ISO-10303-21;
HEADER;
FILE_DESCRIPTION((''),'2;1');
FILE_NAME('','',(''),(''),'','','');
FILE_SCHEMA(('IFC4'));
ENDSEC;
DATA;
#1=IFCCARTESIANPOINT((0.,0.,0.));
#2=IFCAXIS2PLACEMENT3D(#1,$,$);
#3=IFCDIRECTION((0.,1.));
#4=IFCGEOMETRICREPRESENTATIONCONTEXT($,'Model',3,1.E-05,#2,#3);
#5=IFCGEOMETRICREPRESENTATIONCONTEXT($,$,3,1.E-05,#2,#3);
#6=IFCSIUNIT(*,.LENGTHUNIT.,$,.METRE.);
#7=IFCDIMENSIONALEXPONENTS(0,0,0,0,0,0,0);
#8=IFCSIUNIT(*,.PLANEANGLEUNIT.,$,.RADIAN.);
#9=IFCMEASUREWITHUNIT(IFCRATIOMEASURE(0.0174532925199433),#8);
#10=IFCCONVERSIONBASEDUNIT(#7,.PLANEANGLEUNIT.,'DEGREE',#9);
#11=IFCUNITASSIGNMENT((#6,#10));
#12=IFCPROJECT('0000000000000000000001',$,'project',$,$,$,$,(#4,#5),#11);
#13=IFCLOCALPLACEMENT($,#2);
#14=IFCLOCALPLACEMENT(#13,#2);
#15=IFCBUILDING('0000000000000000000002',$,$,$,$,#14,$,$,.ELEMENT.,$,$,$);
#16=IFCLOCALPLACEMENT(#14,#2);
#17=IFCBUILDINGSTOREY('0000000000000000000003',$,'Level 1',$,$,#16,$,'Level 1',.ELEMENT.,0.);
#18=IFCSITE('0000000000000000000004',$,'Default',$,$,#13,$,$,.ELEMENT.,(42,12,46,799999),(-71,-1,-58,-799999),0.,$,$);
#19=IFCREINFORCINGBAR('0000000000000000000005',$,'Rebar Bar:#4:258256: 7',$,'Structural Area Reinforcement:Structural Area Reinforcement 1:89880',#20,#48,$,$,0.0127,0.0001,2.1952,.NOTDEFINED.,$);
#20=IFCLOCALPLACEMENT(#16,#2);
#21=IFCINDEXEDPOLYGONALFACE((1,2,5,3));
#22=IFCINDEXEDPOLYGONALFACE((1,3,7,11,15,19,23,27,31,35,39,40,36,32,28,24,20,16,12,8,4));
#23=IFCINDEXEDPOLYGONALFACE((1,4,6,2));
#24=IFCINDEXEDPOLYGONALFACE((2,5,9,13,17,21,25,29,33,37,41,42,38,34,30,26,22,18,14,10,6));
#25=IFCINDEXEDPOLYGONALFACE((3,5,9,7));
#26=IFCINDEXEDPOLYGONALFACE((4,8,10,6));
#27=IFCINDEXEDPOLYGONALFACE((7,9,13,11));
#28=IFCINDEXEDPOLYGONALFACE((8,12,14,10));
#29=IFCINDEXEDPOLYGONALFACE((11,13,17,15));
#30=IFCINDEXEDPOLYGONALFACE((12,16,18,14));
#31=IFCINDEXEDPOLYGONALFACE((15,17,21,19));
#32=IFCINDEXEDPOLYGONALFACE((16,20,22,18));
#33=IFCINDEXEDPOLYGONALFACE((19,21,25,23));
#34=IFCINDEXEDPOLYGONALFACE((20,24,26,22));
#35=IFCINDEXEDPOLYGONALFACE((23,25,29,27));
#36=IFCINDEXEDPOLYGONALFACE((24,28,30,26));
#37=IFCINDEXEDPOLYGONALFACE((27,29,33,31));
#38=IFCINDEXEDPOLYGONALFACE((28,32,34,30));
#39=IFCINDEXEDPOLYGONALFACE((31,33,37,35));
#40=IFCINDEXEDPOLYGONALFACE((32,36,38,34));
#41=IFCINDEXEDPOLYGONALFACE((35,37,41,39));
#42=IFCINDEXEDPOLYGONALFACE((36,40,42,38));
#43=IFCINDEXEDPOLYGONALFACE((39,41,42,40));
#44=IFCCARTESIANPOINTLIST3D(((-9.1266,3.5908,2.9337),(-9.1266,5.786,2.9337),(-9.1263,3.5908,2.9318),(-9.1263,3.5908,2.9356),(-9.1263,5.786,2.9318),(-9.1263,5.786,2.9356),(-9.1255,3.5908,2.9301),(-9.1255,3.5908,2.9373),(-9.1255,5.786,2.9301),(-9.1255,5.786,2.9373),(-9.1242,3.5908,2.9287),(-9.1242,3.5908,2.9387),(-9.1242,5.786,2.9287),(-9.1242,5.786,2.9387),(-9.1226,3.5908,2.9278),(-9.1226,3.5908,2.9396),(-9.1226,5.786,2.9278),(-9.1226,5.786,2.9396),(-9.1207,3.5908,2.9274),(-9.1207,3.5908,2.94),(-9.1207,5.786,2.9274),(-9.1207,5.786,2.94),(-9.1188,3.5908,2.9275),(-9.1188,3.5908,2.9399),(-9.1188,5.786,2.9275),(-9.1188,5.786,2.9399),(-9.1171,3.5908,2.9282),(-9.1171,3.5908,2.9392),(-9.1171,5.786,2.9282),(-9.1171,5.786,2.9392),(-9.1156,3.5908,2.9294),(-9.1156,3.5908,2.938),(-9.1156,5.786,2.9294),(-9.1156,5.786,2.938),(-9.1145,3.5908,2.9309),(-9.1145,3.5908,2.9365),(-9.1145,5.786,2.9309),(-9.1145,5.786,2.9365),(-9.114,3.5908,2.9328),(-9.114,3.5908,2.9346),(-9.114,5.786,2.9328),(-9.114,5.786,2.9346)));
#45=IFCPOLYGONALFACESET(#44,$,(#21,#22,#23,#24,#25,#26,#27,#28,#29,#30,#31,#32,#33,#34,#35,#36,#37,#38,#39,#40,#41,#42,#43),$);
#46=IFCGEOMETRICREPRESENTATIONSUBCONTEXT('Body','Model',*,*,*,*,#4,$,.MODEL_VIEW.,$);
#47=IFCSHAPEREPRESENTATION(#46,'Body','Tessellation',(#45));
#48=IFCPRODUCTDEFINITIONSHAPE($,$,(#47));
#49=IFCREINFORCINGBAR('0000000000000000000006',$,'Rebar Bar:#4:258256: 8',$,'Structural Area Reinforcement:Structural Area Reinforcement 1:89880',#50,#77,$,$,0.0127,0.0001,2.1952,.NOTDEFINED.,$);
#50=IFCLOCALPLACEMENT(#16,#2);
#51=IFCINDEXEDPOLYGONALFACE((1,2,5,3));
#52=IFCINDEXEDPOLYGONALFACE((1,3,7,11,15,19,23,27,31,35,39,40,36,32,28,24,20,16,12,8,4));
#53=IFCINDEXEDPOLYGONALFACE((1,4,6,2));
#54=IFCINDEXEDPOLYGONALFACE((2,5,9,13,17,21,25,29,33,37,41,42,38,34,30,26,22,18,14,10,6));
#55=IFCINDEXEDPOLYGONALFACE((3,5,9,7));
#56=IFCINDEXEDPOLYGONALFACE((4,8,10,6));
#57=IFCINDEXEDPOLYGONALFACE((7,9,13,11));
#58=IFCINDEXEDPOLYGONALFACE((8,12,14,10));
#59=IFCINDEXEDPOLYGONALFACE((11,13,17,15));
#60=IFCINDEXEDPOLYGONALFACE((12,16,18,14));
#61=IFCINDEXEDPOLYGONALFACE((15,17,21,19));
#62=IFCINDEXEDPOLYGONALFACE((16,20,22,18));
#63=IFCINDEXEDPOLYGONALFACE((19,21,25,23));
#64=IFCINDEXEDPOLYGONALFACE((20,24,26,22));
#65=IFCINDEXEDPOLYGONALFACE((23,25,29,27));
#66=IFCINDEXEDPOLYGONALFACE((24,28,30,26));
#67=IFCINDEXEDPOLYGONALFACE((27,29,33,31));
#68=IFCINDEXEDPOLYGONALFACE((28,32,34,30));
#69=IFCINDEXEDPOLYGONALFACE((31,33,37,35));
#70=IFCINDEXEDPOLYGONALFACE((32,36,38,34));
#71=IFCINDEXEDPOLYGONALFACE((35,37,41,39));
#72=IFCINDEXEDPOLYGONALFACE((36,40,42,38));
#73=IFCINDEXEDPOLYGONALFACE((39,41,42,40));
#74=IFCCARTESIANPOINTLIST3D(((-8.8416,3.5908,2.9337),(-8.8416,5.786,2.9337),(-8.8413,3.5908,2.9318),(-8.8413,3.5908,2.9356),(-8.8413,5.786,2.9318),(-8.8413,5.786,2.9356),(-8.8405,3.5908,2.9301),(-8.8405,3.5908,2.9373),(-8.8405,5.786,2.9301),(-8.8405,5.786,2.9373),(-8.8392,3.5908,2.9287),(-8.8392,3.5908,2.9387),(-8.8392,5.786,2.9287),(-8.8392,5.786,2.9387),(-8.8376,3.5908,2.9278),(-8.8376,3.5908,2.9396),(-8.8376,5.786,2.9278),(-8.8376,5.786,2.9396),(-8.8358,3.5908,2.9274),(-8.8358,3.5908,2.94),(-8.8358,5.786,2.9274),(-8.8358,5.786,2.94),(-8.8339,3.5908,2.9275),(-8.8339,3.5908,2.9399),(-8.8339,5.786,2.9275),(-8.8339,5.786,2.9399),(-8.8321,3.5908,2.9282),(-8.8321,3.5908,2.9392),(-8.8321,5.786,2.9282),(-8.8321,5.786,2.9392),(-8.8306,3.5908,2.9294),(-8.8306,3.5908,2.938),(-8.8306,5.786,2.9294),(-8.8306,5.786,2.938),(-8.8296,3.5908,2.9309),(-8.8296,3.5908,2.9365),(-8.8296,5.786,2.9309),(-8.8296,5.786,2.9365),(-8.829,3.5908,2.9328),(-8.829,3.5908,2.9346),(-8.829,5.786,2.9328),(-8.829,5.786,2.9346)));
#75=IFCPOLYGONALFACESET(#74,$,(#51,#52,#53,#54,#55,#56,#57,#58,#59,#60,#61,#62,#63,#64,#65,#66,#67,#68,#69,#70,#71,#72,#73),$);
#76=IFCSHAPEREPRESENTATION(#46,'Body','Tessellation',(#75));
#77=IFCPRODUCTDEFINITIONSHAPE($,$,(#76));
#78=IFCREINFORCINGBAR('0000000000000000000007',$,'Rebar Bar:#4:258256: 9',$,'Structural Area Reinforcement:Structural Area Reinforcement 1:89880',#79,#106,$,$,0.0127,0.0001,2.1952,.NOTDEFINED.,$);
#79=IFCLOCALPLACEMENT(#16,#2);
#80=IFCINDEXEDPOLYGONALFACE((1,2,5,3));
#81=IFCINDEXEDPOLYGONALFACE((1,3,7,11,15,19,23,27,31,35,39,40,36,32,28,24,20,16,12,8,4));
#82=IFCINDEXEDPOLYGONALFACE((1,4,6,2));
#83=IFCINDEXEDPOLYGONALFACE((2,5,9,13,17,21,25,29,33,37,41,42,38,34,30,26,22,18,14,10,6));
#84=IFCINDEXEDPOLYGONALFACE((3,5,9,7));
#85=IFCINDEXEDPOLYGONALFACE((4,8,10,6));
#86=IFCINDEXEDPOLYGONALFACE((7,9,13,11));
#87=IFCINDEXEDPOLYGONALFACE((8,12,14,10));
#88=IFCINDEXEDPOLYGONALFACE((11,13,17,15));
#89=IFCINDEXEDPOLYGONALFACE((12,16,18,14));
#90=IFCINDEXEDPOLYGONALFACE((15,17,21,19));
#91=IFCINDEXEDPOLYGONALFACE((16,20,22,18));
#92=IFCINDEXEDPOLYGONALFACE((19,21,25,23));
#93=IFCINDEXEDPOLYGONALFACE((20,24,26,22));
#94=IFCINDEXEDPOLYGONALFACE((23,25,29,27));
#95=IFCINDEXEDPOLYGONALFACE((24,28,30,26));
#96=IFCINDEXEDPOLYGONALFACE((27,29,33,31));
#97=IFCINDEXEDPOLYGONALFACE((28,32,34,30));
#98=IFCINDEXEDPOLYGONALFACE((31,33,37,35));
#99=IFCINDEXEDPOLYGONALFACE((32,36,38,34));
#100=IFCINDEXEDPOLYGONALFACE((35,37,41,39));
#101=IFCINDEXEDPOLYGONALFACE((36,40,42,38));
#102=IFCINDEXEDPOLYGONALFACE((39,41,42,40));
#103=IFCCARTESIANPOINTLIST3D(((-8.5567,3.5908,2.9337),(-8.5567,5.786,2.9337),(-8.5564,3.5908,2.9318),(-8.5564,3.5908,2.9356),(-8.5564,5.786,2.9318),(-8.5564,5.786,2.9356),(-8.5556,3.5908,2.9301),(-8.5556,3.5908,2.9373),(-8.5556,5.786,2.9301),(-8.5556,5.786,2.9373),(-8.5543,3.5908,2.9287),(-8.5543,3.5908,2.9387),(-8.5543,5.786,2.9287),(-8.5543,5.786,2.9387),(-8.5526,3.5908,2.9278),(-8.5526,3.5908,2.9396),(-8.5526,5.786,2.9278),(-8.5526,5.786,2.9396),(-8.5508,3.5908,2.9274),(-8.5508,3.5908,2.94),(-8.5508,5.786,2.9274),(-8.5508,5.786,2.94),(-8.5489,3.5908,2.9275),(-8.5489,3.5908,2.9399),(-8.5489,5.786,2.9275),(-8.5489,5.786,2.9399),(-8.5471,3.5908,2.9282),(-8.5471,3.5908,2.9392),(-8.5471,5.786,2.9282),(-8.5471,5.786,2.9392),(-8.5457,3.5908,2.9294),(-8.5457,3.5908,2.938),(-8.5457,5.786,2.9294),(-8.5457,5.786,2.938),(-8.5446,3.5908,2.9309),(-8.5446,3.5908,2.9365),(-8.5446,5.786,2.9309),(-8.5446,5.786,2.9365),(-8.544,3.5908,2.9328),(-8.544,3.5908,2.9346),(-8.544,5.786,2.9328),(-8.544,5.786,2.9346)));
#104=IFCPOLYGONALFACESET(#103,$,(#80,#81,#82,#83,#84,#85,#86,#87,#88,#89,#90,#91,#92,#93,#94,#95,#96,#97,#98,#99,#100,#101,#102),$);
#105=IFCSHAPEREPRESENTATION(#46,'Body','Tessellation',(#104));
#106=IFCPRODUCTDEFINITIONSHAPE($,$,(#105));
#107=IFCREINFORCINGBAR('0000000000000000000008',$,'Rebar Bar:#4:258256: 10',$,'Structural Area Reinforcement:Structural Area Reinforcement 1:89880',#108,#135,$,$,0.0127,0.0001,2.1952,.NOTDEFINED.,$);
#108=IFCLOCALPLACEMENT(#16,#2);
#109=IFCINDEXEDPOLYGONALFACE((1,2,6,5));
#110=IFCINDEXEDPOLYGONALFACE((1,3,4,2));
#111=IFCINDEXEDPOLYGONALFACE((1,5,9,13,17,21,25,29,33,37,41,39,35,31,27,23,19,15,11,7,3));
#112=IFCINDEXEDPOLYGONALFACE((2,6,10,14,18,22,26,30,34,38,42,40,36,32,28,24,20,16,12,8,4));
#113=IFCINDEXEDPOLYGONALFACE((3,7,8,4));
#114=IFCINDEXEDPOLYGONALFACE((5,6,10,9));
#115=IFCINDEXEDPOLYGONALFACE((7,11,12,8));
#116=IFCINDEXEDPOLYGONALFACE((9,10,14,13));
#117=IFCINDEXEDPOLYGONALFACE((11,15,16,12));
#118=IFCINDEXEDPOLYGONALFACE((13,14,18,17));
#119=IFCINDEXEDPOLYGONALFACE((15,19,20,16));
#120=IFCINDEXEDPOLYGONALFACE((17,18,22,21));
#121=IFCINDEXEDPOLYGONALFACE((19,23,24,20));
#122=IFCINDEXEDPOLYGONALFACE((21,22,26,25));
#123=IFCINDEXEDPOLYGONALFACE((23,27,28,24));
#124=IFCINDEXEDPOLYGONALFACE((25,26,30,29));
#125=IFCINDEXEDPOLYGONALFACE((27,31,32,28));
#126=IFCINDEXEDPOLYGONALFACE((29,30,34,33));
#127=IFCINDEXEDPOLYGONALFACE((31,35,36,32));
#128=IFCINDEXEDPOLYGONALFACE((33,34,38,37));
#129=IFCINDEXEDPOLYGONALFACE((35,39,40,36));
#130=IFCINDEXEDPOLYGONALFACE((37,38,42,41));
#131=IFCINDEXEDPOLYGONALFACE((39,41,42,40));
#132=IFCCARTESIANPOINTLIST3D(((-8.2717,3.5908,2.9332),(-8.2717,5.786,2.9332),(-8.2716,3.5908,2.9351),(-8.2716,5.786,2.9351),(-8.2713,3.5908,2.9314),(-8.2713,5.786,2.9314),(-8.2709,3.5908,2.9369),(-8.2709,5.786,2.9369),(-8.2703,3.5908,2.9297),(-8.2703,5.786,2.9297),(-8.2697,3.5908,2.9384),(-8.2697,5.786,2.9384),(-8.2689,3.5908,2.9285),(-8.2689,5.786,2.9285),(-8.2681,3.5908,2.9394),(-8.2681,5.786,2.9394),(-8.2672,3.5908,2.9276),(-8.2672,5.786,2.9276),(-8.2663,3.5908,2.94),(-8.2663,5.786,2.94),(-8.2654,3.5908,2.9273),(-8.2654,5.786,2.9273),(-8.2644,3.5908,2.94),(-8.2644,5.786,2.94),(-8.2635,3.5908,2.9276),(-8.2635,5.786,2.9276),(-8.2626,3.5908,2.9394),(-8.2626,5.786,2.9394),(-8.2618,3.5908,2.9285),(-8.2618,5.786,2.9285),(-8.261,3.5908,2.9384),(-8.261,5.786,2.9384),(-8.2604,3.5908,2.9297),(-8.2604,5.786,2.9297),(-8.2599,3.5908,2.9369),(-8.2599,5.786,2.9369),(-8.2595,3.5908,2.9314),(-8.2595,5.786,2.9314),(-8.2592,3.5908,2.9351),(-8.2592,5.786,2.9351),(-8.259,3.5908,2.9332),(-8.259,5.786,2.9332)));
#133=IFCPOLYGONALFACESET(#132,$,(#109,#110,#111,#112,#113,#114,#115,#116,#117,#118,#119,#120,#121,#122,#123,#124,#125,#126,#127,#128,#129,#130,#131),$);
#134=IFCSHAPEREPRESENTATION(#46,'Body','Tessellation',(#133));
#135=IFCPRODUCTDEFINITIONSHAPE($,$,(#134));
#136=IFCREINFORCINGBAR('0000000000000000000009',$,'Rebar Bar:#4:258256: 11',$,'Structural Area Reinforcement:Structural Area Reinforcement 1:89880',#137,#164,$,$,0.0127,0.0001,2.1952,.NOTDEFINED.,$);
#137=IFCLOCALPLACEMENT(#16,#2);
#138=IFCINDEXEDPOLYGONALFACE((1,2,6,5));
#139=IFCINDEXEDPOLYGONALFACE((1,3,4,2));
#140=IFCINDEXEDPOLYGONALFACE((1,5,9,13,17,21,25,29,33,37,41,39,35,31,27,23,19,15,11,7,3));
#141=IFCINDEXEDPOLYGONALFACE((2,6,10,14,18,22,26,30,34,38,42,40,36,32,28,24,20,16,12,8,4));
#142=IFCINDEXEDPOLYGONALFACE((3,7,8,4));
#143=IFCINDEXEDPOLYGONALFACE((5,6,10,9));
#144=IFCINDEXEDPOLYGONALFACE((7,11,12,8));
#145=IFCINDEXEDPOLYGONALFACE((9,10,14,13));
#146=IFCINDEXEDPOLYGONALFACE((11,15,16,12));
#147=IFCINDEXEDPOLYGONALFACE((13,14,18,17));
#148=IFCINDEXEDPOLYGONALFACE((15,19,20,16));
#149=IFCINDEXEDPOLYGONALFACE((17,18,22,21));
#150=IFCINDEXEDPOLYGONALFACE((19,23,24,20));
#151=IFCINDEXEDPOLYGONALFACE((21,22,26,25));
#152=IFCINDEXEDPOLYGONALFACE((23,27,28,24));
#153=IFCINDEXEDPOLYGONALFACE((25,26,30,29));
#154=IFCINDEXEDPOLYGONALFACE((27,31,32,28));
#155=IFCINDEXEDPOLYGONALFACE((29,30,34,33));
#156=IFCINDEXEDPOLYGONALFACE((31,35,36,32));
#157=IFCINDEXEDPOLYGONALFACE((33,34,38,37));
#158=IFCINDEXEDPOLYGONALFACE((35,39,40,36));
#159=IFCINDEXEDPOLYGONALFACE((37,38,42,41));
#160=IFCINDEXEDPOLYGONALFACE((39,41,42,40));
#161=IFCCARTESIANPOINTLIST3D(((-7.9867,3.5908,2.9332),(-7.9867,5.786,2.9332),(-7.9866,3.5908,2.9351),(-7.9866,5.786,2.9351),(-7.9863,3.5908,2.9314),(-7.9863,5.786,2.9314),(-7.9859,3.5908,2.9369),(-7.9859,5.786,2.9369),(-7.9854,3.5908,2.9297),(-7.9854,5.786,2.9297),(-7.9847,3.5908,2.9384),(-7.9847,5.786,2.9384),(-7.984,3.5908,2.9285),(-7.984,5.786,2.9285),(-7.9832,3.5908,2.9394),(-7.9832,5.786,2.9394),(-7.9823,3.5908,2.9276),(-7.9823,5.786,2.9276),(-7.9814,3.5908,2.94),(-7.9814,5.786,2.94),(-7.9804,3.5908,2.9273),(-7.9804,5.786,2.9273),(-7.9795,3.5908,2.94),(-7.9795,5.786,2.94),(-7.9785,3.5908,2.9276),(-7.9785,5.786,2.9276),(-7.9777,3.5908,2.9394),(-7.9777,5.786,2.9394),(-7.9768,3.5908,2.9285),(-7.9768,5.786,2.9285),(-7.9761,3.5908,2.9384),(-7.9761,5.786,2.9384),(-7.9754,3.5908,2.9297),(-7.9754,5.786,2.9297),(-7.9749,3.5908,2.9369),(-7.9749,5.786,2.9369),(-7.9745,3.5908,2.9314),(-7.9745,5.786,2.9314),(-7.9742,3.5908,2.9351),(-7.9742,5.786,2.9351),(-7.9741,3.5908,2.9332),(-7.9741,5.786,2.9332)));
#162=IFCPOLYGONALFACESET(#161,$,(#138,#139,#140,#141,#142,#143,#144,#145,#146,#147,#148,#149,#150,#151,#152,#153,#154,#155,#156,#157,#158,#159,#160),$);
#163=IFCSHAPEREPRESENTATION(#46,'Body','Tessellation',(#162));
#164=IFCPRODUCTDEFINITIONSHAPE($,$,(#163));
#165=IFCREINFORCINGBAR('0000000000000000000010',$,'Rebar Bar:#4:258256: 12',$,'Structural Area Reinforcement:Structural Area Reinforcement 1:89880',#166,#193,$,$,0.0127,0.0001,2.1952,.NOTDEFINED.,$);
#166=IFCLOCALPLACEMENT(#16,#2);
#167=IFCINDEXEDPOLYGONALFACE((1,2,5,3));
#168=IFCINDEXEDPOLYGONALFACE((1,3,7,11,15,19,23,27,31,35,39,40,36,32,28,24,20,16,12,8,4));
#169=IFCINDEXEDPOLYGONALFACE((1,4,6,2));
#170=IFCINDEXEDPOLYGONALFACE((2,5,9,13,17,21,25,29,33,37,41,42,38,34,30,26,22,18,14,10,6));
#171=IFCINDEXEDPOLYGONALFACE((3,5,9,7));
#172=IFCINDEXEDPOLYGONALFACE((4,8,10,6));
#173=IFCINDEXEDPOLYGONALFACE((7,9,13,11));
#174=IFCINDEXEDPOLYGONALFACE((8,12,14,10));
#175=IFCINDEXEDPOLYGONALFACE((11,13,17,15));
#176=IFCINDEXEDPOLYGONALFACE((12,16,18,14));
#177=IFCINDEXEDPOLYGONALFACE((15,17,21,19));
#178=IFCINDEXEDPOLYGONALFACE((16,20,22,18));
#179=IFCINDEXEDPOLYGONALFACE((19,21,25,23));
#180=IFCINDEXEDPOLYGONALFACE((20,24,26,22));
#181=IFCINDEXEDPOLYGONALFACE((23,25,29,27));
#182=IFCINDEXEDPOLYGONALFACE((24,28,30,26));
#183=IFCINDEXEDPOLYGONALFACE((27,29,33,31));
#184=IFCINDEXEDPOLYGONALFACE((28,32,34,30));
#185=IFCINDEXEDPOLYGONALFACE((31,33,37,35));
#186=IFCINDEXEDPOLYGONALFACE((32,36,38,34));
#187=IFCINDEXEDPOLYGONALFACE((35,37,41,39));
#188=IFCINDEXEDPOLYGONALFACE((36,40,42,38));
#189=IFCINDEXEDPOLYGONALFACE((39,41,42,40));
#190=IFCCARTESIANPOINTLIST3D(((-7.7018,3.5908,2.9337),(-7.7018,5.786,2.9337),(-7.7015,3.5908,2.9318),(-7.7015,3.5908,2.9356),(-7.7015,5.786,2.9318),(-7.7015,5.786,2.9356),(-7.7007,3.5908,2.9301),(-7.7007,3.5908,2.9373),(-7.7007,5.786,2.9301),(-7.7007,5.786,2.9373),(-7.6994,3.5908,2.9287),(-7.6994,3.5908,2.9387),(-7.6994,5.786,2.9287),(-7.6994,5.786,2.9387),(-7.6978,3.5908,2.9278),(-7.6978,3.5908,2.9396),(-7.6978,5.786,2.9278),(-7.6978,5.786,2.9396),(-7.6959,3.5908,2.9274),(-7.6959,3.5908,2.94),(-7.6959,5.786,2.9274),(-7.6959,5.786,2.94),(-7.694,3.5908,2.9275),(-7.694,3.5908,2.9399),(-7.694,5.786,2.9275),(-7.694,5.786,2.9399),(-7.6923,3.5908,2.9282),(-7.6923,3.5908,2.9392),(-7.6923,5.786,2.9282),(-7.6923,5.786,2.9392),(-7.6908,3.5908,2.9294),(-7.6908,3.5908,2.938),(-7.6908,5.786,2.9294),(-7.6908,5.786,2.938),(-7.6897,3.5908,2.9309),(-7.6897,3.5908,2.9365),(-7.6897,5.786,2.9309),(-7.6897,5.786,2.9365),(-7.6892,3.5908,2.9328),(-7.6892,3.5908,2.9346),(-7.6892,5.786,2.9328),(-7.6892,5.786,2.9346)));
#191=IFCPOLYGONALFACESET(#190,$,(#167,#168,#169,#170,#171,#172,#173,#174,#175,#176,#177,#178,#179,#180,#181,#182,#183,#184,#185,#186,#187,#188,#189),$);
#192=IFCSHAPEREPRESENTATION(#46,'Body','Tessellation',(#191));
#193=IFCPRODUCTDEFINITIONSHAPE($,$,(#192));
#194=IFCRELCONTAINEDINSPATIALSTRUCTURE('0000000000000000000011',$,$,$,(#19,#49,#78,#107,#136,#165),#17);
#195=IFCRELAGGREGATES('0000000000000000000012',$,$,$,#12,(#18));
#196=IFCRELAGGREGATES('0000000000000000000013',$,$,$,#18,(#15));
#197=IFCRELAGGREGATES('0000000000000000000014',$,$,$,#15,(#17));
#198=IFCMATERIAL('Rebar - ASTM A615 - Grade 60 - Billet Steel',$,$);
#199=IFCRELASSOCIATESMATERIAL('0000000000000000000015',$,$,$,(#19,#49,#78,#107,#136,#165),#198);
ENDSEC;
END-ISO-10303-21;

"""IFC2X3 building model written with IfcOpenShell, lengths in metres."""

from ifc_helpers import new_model, entity, si_unit, converted_unit, direction, origin, place, context, subcontext, project, spatial, material, element, save


model = new_model("IFC2X3")

# Units and contexts
model_context = context("Model", 3, precision=1e-05, world=origin(), true_north=direction((0.0, 1.0)))
context_of_model = context(None, 3, precision=1e-05, world=origin(), true_north=direction((0.0, 1.0)))
body_context = subcontext(model_context, "Body", "Model", "MODEL_VIEW")
ifc_project = project(units=[si_unit("LENGTHUNIT", "METRE"), converted_unit("PLANEANGLEUNIT", "DEGREE", entity("IfcRatioMeasure", 0.0174532925199433), si_unit("PLANEANGLEUNIT", "RADIAN"), dimensions=[0, 0, 0, 0, 0, 0, 0])], contexts=[model_context, context_of_model])

# Site, building, storey
site_placement = place(None, origin())
site = spatial("IfcSite", under=ifc_project, at=site_placement, Name="Default", CompositionType="ELEMENT", RefLatitude=(42, 12, 46, 799999), RefLongitude=(-71, -1, -58, -799999), RefElevation=0.0)
building_placement = place(site_placement, origin())
building = spatial("IfcBuilding", under=site, at=building_placement, CompositionType="ELEMENT")
storey_placement = place(building_placement, origin())
storey = spatial("IfcBuildingStorey", under=building, at=storey_placement, Name="Level 1", LongName="Level 1", CompositionType="ELEMENT", Elevation=0.0)

# Shared definitions
ifc_material_1 = material(Name="Rebar - ASTM A615 - Grade 60 - Billet Steel")

# Reinforcing bars
reinforcing_bar_1_placement = place(storey_placement, origin())
element("IfcReinforcingBar", 1, at=reinforcing_bar_1_placement, inside=storey, material=ifc_material_1, Name="Rebar Bar:#4:258256: 7", ObjectType="Structural Area Reinforcement:Structural Area Reinforcement 1:89880", BarLength=2.1952, BarRole="NOTDEFINED", CrossSectionArea=0.0001, NominalDiameter=0.0127, context=body_context, shape_type="AdvancedSweptSolid", body=[
    entity("IfcSweptDiskSolid", entity("IfcCompositeCurve", [entity("IfcCompositeCurveSegment", "CONTINUOUS", True, entity("IfcPolyline", [entity("IfcCartesianPoint", [-9.1202, 5.786, 2.9337]), entity("IfcCartesianPoint", [-9.1202, 3.5908, 2.9337])]))], False), 0.0063, None, 0.0, 1.0),
])
reinforcing_bar_2_placement = place(storey_placement, origin())
element("IfcReinforcingBar", 2, at=reinforcing_bar_2_placement, inside=storey, material=ifc_material_1, Name="Rebar Bar:#4:258256: 8", ObjectType="Structural Area Reinforcement:Structural Area Reinforcement 1:89880", BarLength=2.1952, BarRole="NOTDEFINED", CrossSectionArea=0.0001, NominalDiameter=0.0127, context=body_context, shape_type="AdvancedSweptSolid", body=[
    entity("IfcSweptDiskSolid", entity("IfcCompositeCurve", [entity("IfcCompositeCurveSegment", "CONTINUOUS", True, entity("IfcPolyline", [entity("IfcCartesianPoint", [-8.8353, 5.786, 2.9337]), entity("IfcCartesianPoint", [-8.8353, 3.5908, 2.9337])]))], False), 0.0063, None, 0.0, 1.0),
])
reinforcing_bar_3_placement = place(storey_placement, origin())
element("IfcReinforcingBar", 3, at=reinforcing_bar_3_placement, inside=storey, material=ifc_material_1, Name="Rebar Bar:#4:258256: 9", ObjectType="Structural Area Reinforcement:Structural Area Reinforcement 1:89880", BarLength=2.1952, BarRole="NOTDEFINED", CrossSectionArea=0.0001, NominalDiameter=0.0127, context=body_context, shape_type="AdvancedSweptSolid", body=[
    entity("IfcSweptDiskSolid", entity("IfcCompositeCurve", [entity("IfcCompositeCurveSegment", "CONTINUOUS", True, entity("IfcPolyline", [entity("IfcCartesianPoint", [-8.5503, 5.786, 2.9337]), entity("IfcCartesianPoint", [-8.5503, 3.5908, 2.9337])]))], False), 0.0063, None, 0.0, 1.0),
])
reinforcing_bar_4_placement = place(storey_placement, origin())
element("IfcReinforcingBar", 4, at=reinforcing_bar_4_placement, inside=storey, material=ifc_material_1, Name="Rebar Bar:#4:258256: 10", ObjectType="Structural Area Reinforcement:Structural Area Reinforcement 1:89880", BarLength=2.1952, BarRole="NOTDEFINED", CrossSectionArea=0.0001, NominalDiameter=0.0127, context=body_context, shape_type="AdvancedSweptSolid", body=[
    entity("IfcSweptDiskSolid", entity("IfcCompositeCurve", [entity("IfcCompositeCurveSegment", "CONTINUOUS", True, entity("IfcPolyline", [entity("IfcCartesianPoint", [-8.2654, 5.786, 2.9337]), entity("IfcCartesianPoint", [-8.2654, 3.5908, 2.9337])]))], False), 0.0063, None, 0.0, 1.0),
])
reinforcing_bar_5_placement = place(storey_placement, origin())
element("IfcReinforcingBar", 5, at=reinforcing_bar_5_placement, inside=storey, material=ifc_material_1, Name="Rebar Bar:#4:258256: 11", ObjectType="Structural Area Reinforcement:Structural Area Reinforcement 1:89880", BarLength=2.1952, BarRole="NOTDEFINED", CrossSectionArea=0.0001, NominalDiameter=0.0127, context=body_context, shape_type="AdvancedSweptSolid", body=[
    entity("IfcSweptDiskSolid", entity("IfcCompositeCurve", [entity("IfcCompositeCurveSegment", "CONTINUOUS", True, entity("IfcPolyline", [entity("IfcCartesianPoint", [-7.9804, 5.786, 2.9337]), entity("IfcCartesianPoint", [-7.9804, 3.5908, 2.9337])]))], False), 0.0063, None, 0.0, 1.0),
])
reinforcing_bar_6_placement = place(storey_placement, origin())
element("IfcReinforcingBar", 6, at=reinforcing_bar_6_placement, inside=storey, material=ifc_material_1, Name="Rebar Bar:#4:258256: 12", ObjectType="Structural Area Reinforcement:Structural Area Reinforcement 1:89880", BarLength=2.1952, BarRole="NOTDEFINED", CrossSectionArea=0.0001, NominalDiameter=0.0127, context=body_context, shape_type="AdvancedSweptSolid", body=[
    entity("IfcSweptDiskSolid", entity("IfcCompositeCurve", [entity("IfcCompositeCurveSegment", "CONTINUOUS", True, entity("IfcPolyline", [entity("IfcCartesianPoint", [-7.6955, 5.786, 2.9337]), entity("IfcCartesianPoint", [-7.6955, 3.5908, 2.9337])]))], False), 0.0063, None, 0.0, 1.0),
])

save(model, "model.ifc")
